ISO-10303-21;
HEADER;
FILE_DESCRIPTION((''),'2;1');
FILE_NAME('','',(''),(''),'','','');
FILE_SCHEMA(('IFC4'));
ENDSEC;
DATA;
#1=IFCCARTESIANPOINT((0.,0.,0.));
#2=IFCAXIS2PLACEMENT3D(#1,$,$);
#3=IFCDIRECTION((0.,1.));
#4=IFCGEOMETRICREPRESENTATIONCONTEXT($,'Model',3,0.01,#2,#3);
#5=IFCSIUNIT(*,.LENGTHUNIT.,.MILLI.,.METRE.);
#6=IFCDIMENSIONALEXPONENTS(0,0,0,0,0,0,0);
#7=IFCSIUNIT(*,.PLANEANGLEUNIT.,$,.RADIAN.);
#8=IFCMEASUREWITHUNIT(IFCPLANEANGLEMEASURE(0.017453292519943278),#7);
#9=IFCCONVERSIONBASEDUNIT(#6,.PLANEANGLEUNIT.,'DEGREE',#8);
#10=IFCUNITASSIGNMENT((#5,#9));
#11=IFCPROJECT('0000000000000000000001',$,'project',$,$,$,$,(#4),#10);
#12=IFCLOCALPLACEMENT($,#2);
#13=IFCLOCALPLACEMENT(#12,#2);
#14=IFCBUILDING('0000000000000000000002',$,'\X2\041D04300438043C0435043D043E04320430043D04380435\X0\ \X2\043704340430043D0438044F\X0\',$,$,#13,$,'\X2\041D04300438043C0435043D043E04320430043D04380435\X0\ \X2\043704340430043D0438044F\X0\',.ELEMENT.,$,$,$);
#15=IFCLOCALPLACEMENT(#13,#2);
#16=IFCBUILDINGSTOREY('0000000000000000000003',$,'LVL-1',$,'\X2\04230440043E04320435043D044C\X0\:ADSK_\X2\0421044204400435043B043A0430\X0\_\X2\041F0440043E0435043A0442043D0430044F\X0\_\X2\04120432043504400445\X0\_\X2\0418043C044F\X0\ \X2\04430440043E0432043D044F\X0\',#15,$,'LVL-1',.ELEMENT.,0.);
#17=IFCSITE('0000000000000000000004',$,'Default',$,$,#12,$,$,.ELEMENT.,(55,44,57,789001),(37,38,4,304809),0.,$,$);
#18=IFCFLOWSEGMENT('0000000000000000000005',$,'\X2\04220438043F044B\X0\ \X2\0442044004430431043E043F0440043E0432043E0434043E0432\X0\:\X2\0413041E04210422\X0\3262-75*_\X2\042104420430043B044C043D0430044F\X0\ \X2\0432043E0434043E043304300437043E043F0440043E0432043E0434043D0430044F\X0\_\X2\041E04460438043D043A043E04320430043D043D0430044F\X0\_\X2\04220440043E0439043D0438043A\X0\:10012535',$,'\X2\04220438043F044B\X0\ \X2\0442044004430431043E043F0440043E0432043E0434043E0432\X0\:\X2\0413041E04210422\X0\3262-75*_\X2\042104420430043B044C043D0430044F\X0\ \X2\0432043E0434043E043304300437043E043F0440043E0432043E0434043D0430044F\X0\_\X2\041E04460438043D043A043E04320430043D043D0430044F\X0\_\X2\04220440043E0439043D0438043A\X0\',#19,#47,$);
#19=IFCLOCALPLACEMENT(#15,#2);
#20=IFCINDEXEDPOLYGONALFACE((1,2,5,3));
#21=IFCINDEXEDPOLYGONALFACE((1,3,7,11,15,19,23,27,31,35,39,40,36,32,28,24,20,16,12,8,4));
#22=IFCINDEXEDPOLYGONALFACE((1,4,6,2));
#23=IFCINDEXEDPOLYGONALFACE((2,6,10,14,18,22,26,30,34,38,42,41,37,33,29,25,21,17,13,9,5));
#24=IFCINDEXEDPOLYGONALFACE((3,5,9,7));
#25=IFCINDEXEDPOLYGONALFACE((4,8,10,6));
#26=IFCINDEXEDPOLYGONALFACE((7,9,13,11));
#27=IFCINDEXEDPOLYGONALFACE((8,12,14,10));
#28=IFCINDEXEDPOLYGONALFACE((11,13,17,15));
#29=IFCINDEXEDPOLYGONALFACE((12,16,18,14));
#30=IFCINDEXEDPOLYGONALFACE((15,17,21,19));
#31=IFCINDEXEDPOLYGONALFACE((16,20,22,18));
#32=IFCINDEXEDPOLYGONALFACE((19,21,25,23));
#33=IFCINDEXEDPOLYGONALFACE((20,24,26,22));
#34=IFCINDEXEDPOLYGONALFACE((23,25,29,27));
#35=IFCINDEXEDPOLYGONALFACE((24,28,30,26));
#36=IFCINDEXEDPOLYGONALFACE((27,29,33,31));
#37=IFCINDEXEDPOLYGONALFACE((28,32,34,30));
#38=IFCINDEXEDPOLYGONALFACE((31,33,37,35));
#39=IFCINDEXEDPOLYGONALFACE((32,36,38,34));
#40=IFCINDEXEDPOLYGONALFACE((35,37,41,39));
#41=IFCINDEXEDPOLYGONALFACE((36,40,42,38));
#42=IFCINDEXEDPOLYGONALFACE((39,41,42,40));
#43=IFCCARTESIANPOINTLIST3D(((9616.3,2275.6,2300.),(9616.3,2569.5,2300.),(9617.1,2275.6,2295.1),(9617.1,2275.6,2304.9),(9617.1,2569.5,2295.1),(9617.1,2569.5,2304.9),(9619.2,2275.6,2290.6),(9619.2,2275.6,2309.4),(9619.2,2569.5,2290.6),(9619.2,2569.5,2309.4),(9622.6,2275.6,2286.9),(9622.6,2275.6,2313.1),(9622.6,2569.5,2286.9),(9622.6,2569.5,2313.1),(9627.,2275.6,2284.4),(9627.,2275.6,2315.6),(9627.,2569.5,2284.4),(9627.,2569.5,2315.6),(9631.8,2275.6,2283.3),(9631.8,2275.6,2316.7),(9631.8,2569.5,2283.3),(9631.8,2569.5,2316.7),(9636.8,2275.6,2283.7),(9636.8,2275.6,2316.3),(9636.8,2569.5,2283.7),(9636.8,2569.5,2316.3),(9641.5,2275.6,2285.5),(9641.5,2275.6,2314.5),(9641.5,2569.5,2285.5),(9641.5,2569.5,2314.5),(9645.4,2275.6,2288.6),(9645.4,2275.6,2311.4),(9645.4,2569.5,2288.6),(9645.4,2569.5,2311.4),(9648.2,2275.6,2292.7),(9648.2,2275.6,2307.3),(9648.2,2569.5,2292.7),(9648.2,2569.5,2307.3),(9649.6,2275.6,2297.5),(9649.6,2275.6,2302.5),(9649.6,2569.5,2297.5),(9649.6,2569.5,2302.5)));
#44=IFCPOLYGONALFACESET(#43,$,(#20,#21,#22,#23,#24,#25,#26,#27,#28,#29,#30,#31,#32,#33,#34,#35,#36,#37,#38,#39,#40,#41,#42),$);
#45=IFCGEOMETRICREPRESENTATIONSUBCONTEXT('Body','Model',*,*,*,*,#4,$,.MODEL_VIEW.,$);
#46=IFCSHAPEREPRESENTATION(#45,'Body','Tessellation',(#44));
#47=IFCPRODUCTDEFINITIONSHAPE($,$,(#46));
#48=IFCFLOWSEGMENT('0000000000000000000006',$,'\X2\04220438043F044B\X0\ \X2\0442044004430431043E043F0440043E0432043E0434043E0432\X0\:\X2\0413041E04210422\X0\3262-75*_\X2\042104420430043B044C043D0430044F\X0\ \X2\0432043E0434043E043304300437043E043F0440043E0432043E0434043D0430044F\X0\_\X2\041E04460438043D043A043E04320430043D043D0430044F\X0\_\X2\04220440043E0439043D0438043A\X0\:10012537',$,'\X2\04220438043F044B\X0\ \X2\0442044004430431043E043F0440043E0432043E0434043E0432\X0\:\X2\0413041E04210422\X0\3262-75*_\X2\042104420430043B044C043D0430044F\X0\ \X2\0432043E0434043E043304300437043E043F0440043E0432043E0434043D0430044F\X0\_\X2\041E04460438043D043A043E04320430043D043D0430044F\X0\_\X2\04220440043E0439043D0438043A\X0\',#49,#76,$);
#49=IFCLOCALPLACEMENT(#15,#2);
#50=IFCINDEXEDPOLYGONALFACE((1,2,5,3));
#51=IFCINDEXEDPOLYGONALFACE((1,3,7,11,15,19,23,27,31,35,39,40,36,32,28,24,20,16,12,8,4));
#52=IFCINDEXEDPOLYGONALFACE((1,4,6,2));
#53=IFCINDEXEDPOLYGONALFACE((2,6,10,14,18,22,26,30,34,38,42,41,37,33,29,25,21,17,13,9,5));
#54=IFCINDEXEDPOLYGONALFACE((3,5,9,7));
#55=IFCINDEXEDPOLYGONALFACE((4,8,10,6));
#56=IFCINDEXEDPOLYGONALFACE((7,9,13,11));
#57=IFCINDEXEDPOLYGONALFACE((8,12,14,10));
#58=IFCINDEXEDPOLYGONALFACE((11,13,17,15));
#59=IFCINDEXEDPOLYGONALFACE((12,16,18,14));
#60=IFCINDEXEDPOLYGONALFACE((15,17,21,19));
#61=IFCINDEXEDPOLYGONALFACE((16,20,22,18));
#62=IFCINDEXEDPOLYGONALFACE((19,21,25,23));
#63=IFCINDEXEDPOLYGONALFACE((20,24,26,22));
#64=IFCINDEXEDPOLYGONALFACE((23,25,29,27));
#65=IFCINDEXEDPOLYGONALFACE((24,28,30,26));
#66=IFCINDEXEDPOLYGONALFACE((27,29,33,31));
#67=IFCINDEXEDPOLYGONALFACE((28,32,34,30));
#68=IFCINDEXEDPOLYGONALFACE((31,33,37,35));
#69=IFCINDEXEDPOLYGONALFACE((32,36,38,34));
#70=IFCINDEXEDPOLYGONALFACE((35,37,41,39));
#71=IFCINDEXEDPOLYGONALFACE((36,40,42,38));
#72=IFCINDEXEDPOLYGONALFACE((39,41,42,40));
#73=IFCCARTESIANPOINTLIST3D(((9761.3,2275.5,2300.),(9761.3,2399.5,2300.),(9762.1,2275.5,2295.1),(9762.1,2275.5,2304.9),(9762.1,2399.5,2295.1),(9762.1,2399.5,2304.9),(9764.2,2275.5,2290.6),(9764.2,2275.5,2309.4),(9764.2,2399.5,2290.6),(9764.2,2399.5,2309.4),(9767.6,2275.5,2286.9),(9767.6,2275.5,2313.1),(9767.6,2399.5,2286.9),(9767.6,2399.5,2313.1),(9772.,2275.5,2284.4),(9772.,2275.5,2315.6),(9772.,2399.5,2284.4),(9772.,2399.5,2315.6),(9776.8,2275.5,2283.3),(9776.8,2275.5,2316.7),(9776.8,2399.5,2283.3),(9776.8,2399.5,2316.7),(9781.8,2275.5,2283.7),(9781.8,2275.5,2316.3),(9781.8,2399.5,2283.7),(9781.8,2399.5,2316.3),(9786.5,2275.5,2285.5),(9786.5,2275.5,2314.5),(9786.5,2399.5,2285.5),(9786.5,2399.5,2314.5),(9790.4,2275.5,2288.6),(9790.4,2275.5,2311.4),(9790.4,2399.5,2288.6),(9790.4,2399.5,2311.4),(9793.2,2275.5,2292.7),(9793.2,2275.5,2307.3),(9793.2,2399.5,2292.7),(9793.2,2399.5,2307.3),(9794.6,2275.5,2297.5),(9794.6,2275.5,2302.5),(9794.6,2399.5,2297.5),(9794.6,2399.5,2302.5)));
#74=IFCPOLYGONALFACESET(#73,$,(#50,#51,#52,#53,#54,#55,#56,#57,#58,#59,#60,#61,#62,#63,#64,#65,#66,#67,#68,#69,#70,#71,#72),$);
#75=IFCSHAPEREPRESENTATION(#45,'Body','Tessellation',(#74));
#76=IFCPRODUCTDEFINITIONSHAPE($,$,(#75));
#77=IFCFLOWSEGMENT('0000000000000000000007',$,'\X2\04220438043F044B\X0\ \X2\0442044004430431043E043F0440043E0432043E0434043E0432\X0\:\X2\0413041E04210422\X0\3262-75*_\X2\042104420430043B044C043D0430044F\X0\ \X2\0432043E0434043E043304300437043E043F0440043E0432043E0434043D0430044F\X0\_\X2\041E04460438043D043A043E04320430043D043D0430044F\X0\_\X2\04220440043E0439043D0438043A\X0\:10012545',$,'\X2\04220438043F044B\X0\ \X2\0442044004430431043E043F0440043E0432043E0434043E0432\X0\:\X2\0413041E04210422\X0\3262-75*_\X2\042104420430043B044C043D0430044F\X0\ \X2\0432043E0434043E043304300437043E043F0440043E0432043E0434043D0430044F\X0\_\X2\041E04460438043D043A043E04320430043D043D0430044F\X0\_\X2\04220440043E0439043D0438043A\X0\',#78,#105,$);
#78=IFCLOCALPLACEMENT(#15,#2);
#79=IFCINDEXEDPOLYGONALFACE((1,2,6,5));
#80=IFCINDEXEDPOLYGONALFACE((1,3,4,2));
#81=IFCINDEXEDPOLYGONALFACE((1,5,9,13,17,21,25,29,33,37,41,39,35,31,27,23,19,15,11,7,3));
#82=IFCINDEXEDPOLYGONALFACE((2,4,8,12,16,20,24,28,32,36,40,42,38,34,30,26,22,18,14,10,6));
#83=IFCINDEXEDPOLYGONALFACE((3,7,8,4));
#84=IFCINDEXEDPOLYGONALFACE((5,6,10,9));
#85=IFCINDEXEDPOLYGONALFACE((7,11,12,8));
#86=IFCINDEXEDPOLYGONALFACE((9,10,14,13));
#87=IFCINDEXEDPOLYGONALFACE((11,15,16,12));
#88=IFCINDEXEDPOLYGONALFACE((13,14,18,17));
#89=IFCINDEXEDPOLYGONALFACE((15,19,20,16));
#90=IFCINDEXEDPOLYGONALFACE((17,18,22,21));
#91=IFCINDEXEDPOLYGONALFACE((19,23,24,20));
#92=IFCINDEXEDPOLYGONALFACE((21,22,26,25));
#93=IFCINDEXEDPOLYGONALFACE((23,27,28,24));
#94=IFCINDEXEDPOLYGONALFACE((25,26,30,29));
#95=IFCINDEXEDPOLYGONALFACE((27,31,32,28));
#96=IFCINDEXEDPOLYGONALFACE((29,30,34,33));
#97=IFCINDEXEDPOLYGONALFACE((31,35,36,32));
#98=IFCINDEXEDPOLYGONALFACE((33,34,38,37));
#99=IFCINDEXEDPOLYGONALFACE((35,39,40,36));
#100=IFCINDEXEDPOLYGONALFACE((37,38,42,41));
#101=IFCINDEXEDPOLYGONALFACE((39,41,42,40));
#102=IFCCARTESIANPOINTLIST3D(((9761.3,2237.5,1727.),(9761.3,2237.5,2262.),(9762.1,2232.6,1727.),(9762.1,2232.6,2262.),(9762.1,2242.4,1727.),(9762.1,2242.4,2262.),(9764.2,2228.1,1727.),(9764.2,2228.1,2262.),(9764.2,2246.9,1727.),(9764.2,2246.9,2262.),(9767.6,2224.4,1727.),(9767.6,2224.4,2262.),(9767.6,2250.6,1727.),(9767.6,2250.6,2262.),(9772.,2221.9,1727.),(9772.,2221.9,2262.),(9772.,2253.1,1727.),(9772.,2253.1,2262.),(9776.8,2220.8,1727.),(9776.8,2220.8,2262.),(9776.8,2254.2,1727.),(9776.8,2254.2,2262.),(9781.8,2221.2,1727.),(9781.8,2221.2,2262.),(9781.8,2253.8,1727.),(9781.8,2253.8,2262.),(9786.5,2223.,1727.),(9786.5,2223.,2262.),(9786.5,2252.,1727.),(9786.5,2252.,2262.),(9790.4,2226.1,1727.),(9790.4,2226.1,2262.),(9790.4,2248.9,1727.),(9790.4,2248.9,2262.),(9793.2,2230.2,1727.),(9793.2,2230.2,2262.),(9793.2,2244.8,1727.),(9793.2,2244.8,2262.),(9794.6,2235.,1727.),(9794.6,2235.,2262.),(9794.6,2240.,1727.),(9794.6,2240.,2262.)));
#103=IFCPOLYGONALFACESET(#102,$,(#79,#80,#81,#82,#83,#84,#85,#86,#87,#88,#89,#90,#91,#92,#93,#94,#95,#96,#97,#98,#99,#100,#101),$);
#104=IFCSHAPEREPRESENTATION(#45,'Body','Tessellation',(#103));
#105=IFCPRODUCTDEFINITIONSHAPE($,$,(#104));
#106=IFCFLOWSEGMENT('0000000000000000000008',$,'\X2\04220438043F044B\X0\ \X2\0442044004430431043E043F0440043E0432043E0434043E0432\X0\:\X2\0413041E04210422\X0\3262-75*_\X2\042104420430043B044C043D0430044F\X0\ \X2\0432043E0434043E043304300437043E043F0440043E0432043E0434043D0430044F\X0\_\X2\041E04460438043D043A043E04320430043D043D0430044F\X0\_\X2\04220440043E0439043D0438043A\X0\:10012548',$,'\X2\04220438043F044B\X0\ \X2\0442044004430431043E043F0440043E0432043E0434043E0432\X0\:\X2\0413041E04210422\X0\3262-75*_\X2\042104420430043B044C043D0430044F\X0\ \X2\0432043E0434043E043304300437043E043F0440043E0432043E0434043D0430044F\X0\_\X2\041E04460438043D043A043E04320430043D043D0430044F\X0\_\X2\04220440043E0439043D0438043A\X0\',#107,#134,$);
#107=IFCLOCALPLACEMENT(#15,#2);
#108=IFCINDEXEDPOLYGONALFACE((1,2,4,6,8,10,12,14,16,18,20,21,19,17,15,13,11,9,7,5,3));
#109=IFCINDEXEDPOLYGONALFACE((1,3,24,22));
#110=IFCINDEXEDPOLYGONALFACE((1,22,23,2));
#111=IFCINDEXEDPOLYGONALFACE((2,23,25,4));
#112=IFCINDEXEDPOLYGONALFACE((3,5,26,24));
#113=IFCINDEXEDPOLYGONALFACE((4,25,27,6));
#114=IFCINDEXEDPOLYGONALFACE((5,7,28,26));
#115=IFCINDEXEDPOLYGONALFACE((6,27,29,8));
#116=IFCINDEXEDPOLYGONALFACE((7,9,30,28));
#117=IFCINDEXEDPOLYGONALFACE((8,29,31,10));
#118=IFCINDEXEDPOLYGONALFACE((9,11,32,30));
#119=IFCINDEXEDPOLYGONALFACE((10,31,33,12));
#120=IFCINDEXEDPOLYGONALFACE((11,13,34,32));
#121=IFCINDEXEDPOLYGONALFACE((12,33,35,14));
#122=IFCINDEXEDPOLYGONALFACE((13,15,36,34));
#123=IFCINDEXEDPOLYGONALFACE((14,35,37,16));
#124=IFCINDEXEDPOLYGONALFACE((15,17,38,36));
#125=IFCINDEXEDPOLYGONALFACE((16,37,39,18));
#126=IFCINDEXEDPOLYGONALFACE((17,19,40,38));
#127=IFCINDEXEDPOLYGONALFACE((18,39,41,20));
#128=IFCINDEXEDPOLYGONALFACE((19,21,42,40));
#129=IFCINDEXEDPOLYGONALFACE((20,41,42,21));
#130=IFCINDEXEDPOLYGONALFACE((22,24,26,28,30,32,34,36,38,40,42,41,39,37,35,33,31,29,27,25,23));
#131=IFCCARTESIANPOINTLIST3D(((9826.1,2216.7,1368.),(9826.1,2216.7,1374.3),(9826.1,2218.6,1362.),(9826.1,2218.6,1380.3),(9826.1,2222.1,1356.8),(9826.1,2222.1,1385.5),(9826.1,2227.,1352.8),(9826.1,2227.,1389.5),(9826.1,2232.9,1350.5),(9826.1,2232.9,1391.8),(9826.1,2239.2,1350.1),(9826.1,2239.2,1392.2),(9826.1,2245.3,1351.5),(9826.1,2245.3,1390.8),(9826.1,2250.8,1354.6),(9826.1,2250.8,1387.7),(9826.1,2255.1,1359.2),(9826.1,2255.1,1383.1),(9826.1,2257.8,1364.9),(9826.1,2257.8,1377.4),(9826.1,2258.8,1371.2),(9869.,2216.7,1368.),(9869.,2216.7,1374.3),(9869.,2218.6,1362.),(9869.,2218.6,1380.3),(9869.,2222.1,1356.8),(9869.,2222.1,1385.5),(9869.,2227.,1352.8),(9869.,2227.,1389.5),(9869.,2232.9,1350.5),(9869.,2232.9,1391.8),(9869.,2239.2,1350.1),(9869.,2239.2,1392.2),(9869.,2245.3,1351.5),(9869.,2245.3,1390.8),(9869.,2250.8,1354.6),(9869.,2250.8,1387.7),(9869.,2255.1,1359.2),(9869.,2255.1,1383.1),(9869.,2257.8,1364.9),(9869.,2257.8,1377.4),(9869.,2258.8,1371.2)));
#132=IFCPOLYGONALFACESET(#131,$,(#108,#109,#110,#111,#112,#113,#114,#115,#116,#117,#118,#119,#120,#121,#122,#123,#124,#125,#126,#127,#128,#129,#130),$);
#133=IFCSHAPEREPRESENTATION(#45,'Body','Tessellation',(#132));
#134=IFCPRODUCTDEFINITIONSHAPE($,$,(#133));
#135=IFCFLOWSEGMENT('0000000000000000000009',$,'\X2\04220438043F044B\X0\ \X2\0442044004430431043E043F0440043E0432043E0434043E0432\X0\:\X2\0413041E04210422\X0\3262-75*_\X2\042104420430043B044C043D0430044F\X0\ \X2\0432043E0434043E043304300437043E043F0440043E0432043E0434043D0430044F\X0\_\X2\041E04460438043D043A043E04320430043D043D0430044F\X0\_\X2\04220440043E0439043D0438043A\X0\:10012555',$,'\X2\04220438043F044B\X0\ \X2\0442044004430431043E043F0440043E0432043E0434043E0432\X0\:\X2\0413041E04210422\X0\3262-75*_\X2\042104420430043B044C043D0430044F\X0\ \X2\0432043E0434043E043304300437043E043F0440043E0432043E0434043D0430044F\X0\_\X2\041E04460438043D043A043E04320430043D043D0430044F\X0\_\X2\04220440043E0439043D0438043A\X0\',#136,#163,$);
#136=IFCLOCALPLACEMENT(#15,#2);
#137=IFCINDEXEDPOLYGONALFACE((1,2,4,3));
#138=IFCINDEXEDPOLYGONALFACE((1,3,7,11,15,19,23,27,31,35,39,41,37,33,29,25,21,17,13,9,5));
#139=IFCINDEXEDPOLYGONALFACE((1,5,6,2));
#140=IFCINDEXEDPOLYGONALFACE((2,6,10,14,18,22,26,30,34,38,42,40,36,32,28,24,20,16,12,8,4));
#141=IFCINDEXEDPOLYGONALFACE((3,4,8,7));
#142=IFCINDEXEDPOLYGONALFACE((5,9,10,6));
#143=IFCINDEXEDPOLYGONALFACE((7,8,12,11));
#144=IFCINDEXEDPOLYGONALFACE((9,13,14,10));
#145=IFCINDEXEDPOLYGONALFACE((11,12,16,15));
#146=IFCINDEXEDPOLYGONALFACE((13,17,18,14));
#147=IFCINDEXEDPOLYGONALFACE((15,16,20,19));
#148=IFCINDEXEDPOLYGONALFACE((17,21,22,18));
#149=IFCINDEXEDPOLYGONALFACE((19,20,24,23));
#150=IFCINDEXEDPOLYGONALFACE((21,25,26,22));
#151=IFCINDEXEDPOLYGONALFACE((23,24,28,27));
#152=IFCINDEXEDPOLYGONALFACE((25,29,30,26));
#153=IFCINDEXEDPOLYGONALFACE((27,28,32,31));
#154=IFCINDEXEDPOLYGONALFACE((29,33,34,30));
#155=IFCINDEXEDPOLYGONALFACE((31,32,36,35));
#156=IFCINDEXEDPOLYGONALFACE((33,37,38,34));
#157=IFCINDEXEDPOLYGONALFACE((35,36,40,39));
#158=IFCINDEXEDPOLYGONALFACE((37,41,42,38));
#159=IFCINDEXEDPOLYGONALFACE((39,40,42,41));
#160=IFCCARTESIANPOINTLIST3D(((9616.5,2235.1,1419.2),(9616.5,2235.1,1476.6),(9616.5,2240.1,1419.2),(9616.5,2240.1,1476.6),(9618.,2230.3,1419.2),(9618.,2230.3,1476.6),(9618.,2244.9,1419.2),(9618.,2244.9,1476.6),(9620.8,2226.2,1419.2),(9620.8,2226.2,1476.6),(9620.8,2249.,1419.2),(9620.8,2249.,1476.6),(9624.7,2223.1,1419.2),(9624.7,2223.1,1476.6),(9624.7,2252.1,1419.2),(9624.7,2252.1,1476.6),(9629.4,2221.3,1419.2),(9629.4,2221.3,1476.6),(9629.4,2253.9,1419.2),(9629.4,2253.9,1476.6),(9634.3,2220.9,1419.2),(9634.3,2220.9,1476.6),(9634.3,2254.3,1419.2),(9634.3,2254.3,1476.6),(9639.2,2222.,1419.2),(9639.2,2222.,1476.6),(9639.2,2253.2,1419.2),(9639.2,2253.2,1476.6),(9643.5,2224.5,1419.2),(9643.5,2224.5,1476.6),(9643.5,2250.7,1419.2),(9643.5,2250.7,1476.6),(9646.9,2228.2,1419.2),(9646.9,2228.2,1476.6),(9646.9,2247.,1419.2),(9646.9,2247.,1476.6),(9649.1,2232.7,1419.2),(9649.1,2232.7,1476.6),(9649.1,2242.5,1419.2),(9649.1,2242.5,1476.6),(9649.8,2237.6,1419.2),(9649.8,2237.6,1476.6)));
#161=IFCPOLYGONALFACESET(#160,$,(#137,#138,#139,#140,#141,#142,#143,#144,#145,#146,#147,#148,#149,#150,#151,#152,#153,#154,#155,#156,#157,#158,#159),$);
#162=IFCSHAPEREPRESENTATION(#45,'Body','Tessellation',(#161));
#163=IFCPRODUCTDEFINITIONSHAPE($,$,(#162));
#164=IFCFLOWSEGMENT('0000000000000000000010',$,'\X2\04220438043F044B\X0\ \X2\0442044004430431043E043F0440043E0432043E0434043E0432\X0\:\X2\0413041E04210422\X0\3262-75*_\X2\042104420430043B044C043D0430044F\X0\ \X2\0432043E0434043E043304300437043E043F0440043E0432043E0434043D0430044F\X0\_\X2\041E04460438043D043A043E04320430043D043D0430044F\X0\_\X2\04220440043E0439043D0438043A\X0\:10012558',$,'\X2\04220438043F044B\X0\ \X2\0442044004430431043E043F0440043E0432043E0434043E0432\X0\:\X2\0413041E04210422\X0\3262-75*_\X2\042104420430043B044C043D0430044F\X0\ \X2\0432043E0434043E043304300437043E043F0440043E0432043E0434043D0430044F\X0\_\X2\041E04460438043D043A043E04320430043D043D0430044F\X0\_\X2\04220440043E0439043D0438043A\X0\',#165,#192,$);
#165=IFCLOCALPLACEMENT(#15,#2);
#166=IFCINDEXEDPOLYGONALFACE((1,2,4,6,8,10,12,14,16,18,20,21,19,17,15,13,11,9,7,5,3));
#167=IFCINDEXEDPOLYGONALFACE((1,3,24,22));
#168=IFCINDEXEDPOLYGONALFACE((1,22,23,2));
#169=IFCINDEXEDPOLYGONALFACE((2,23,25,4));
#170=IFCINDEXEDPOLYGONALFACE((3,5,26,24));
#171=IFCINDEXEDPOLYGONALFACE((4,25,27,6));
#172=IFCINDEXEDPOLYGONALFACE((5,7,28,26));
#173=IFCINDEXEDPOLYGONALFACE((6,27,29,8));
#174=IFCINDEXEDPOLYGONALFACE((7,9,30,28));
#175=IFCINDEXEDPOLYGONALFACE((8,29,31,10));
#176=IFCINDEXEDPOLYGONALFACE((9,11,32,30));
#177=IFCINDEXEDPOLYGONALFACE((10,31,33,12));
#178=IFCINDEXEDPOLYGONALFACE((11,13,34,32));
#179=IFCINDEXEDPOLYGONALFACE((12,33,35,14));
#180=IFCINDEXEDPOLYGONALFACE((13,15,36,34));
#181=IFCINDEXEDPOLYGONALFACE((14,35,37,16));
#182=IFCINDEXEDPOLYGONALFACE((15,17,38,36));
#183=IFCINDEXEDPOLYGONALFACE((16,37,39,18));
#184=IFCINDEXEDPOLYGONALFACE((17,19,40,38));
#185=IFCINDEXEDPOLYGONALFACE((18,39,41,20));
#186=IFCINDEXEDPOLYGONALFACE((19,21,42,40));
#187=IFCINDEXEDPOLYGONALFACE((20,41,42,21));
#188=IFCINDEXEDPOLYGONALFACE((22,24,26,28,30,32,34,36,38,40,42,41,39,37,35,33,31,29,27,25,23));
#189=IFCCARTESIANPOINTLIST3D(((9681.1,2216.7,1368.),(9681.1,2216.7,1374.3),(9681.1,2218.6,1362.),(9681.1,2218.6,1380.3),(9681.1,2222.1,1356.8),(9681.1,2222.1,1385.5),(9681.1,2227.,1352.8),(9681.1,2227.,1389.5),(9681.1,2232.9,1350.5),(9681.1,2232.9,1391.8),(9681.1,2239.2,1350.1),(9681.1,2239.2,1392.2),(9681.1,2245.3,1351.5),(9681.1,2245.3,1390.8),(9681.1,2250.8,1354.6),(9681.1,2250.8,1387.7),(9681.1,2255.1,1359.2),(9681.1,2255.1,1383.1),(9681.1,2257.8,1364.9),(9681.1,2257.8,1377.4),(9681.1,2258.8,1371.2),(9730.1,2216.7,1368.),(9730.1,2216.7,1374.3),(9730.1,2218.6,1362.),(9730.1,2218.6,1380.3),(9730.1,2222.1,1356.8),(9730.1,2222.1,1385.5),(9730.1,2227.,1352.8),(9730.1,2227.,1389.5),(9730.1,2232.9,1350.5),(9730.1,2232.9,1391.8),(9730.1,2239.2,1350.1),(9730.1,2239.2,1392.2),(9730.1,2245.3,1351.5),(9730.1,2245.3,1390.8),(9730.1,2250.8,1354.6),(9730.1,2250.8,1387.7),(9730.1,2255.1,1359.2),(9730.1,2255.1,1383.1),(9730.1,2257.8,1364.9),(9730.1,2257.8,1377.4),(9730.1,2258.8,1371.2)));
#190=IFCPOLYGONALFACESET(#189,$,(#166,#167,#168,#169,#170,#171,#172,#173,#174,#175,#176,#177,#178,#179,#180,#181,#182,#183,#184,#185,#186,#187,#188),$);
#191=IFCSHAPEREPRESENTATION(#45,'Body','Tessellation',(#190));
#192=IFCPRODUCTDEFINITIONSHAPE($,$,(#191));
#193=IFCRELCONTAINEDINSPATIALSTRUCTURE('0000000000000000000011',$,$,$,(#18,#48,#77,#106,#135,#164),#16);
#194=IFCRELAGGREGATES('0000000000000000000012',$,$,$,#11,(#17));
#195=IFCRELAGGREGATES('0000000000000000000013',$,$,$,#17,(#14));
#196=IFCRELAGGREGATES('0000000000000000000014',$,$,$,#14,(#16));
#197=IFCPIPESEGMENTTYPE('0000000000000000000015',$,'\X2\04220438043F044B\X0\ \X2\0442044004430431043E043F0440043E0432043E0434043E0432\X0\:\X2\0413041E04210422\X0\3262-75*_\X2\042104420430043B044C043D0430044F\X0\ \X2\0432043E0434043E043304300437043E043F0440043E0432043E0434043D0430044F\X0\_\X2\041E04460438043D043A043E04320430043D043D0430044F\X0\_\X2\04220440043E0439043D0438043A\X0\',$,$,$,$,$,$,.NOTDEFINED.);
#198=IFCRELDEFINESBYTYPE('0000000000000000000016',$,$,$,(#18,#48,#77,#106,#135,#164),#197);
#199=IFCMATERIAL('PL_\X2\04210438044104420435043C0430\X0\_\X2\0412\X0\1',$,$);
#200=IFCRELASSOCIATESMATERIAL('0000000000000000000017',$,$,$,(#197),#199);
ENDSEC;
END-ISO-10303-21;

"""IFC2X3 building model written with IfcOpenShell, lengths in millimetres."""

from ifc_helpers import new_model, entity, si_unit, converted_unit, direction, frame, frame_2d, origin, origin_2d_with_axis, place, context, subcontext, project, spatial, circle, extrude, material, type_object, element, save


model = new_model("IFC2X3")

# Units and contexts
model_context = context("Model", 3, precision=0.01, world=origin(), true_north=direction((0.0, 1.0)))
body_context = subcontext(model_context, "Body", "Model", "MODEL_VIEW")
ifc_project = project(units=[si_unit("LENGTHUNIT", "METRE", prefix="MILLI"), converted_unit("PLANEANGLEUNIT", "DEGREE", entity("IfcPlaneAngleMeasure", 0.017453292519943278), si_unit("PLANEANGLEUNIT", "RADIAN"), dimensions=[0, 0, 0, 0, 0, 0, 0])], contexts=[model_context])

# Site, building, storey
site_placement = place(None, origin())
site = spatial("IfcSite", under=ifc_project, at=site_placement, Name="Default", CompositionType="ELEMENT", RefLatitude=(55, 44, 57, 789001), RefLongitude=(37, 38, 4, 304809), RefElevation=0.0)
building_placement = place(site_placement, origin())
building = spatial("IfcBuilding", under=site, at=building_placement, Name="Наименование здания", LongName="Наименование здания", CompositionType="ELEMENT")
storey_placement = place(building_placement, origin())
storey = spatial("IfcBuildingStorey", under=building, at=storey_placement, Name="LVL-1", ObjectType="Уровень:ADSK_Стрелка_Проектная_Вверх_Имя уровня", LongName="LVL-1", CompositionType="ELEMENT", Elevation=0.0)

# Flow segments
ifc_material_1 = material(Name="PL_Система_В1")
pipe_segment_type_1 = type_object("IfcPipeSegmentType", Name="Типы трубопроводов:ГОСТ3262-75*_Стальная водогазопроводная_Оцинкованная_Тройник", PredefinedType="NOTDEFINED", material=ifc_material_1)
flow_segment_1_placement = place(storey_placement, origin())
element("IfcFlowSegment", 1, at=flow_segment_1_placement, inside=storey, type_object=pipe_segment_type_1, Name="Типы трубопроводов:ГОСТ3262-75*_Стальная водогазопроводная_Оцинкованная_Тройник:10012535", ObjectType="Типы трубопроводов:ГОСТ3262-75*_Стальная водогазопроводная_Оцинкованная_Тройник", context=body_context, shape_type="SweptSolid", body=[
    extrude(circle(Radius=16.8, at=frame_2d((0.0, 0.0), x_axis=(1.0, 0.0))), frame((9633.1, 2275.6, 2300.0), z_axis=(0.0, 1.0, 0.0), x_axis=(-1.0, 0.0, 0.0)), (0.0, 0.0, 1.0), 293.9),
])
flow_segment_2_placement = place(storey_placement, origin())
element("IfcFlowSegment", 2, at=flow_segment_2_placement, inside=storey, type_object=pipe_segment_type_1, Name="Типы трубопроводов:ГОСТ3262-75*_Стальная водогазопроводная_Оцинкованная_Тройник:10012537", ObjectType="Типы трубопроводов:ГОСТ3262-75*_Стальная водогазопроводная_Оцинкованная_Тройник", context=body_context, shape_type="SweptSolid", body=[
    extrude(circle(Radius=16.8, at=origin_2d_with_axis()), frame((9778.1, 2275.5, 2300.0), z_axis=(0.0, 1.0, 0.0), x_axis=(-1.0, 0.0, 0.0)), (0.0, 0.0, 1.0), 124.0),
])
flow_segment_3_placement = place(storey_placement, origin())
element("IfcFlowSegment", 3, at=flow_segment_3_placement, inside=storey, type_object=pipe_segment_type_1, Name="Типы трубопроводов:ГОСТ3262-75*_Стальная водогазопроводная_Оцинкованная_Тройник:10012545", ObjectType="Типы трубопроводов:ГОСТ3262-75*_Стальная водогазопроводная_Оцинкованная_Тройник", context=body_context, shape_type="SweptSolid", body=[
    extrude(circle(Radius=16.8, at=origin_2d_with_axis()), frame((9778.1, 2237.5, 1727.0), z_axis=(0.0, 0.0, 1.0), x_axis=(-1.0, 0.0, 0.0)), (0.0, 0.0, 1.0), 535.0),
])
flow_segment_4_placement = place(storey_placement, origin())
element("IfcFlowSegment", 4, at=flow_segment_4_placement, inside=storey, type_object=pipe_segment_type_1, Name="Типы трубопроводов:ГОСТ3262-75*_Стальная водогазопроводная_Оцинкованная_Тройник:10012548", ObjectType="Типы трубопроводов:ГОСТ3262-75*_Стальная водогазопроводная_Оцинкованная_Тройник", context=body_context, shape_type="SweptSolid", body=[
    extrude(circle(Radius=21.1, at=frame_2d((0.0, 0.0), x_axis=(1.0, 0.0))), frame((9826.1, 2237.6, 1371.2), z_axis=(1.0, 0.0, 0.0), x_axis=(0.0, 1.0, 0.0)), (0.0, 0.0, 1.0), 43.0),
])
flow_segment_5_placement = place(storey_placement, origin())
element("IfcFlowSegment", 5, at=flow_segment_5_placement, inside=storey, type_object=pipe_segment_type_1, Name="Типы трубопроводов:ГОСТ3262-75*_Стальная водогазопроводная_Оцинкованная_Тройник:10012555", ObjectType="Типы трубопроводов:ГОСТ3262-75*_Стальная водогазопроводная_Оцинкованная_Тройник", context=body_context, shape_type="SweptSolid", body=[
    extrude(circle(Radius=16.8, at=origin_2d_with_axis()), frame((9633.1, 2237.6, 1419.2)), (0.0, 0.0, 1.0), 57.4),
])
flow_segment_6_placement = place(storey_placement, origin())
element("IfcFlowSegment", 6, at=flow_segment_6_placement, inside=storey, type_object=pipe_segment_type_1, Name="Типы трубопроводов:ГОСТ3262-75*_Стальная водогазопроводная_Оцинкованная_Тройник:10012558", ObjectType="Типы трубопроводов:ГОСТ3262-75*_Стальная водогазопроводная_Оцинкованная_Тройник", context=body_context, shape_type="SweptSolid", body=[
    extrude(circle(Radius=21.1, at=frame_2d((0.0, 0.0), x_axis=(1.0, 0.0))), frame((9681.1, 2237.6, 1371.2), z_axis=(1.0, 0.0, 0.0), x_axis=(0.0, 1.0, 0.0)), (0.0, 0.0, 1.0), 49.0),
])

save(model, "model.ifc")
